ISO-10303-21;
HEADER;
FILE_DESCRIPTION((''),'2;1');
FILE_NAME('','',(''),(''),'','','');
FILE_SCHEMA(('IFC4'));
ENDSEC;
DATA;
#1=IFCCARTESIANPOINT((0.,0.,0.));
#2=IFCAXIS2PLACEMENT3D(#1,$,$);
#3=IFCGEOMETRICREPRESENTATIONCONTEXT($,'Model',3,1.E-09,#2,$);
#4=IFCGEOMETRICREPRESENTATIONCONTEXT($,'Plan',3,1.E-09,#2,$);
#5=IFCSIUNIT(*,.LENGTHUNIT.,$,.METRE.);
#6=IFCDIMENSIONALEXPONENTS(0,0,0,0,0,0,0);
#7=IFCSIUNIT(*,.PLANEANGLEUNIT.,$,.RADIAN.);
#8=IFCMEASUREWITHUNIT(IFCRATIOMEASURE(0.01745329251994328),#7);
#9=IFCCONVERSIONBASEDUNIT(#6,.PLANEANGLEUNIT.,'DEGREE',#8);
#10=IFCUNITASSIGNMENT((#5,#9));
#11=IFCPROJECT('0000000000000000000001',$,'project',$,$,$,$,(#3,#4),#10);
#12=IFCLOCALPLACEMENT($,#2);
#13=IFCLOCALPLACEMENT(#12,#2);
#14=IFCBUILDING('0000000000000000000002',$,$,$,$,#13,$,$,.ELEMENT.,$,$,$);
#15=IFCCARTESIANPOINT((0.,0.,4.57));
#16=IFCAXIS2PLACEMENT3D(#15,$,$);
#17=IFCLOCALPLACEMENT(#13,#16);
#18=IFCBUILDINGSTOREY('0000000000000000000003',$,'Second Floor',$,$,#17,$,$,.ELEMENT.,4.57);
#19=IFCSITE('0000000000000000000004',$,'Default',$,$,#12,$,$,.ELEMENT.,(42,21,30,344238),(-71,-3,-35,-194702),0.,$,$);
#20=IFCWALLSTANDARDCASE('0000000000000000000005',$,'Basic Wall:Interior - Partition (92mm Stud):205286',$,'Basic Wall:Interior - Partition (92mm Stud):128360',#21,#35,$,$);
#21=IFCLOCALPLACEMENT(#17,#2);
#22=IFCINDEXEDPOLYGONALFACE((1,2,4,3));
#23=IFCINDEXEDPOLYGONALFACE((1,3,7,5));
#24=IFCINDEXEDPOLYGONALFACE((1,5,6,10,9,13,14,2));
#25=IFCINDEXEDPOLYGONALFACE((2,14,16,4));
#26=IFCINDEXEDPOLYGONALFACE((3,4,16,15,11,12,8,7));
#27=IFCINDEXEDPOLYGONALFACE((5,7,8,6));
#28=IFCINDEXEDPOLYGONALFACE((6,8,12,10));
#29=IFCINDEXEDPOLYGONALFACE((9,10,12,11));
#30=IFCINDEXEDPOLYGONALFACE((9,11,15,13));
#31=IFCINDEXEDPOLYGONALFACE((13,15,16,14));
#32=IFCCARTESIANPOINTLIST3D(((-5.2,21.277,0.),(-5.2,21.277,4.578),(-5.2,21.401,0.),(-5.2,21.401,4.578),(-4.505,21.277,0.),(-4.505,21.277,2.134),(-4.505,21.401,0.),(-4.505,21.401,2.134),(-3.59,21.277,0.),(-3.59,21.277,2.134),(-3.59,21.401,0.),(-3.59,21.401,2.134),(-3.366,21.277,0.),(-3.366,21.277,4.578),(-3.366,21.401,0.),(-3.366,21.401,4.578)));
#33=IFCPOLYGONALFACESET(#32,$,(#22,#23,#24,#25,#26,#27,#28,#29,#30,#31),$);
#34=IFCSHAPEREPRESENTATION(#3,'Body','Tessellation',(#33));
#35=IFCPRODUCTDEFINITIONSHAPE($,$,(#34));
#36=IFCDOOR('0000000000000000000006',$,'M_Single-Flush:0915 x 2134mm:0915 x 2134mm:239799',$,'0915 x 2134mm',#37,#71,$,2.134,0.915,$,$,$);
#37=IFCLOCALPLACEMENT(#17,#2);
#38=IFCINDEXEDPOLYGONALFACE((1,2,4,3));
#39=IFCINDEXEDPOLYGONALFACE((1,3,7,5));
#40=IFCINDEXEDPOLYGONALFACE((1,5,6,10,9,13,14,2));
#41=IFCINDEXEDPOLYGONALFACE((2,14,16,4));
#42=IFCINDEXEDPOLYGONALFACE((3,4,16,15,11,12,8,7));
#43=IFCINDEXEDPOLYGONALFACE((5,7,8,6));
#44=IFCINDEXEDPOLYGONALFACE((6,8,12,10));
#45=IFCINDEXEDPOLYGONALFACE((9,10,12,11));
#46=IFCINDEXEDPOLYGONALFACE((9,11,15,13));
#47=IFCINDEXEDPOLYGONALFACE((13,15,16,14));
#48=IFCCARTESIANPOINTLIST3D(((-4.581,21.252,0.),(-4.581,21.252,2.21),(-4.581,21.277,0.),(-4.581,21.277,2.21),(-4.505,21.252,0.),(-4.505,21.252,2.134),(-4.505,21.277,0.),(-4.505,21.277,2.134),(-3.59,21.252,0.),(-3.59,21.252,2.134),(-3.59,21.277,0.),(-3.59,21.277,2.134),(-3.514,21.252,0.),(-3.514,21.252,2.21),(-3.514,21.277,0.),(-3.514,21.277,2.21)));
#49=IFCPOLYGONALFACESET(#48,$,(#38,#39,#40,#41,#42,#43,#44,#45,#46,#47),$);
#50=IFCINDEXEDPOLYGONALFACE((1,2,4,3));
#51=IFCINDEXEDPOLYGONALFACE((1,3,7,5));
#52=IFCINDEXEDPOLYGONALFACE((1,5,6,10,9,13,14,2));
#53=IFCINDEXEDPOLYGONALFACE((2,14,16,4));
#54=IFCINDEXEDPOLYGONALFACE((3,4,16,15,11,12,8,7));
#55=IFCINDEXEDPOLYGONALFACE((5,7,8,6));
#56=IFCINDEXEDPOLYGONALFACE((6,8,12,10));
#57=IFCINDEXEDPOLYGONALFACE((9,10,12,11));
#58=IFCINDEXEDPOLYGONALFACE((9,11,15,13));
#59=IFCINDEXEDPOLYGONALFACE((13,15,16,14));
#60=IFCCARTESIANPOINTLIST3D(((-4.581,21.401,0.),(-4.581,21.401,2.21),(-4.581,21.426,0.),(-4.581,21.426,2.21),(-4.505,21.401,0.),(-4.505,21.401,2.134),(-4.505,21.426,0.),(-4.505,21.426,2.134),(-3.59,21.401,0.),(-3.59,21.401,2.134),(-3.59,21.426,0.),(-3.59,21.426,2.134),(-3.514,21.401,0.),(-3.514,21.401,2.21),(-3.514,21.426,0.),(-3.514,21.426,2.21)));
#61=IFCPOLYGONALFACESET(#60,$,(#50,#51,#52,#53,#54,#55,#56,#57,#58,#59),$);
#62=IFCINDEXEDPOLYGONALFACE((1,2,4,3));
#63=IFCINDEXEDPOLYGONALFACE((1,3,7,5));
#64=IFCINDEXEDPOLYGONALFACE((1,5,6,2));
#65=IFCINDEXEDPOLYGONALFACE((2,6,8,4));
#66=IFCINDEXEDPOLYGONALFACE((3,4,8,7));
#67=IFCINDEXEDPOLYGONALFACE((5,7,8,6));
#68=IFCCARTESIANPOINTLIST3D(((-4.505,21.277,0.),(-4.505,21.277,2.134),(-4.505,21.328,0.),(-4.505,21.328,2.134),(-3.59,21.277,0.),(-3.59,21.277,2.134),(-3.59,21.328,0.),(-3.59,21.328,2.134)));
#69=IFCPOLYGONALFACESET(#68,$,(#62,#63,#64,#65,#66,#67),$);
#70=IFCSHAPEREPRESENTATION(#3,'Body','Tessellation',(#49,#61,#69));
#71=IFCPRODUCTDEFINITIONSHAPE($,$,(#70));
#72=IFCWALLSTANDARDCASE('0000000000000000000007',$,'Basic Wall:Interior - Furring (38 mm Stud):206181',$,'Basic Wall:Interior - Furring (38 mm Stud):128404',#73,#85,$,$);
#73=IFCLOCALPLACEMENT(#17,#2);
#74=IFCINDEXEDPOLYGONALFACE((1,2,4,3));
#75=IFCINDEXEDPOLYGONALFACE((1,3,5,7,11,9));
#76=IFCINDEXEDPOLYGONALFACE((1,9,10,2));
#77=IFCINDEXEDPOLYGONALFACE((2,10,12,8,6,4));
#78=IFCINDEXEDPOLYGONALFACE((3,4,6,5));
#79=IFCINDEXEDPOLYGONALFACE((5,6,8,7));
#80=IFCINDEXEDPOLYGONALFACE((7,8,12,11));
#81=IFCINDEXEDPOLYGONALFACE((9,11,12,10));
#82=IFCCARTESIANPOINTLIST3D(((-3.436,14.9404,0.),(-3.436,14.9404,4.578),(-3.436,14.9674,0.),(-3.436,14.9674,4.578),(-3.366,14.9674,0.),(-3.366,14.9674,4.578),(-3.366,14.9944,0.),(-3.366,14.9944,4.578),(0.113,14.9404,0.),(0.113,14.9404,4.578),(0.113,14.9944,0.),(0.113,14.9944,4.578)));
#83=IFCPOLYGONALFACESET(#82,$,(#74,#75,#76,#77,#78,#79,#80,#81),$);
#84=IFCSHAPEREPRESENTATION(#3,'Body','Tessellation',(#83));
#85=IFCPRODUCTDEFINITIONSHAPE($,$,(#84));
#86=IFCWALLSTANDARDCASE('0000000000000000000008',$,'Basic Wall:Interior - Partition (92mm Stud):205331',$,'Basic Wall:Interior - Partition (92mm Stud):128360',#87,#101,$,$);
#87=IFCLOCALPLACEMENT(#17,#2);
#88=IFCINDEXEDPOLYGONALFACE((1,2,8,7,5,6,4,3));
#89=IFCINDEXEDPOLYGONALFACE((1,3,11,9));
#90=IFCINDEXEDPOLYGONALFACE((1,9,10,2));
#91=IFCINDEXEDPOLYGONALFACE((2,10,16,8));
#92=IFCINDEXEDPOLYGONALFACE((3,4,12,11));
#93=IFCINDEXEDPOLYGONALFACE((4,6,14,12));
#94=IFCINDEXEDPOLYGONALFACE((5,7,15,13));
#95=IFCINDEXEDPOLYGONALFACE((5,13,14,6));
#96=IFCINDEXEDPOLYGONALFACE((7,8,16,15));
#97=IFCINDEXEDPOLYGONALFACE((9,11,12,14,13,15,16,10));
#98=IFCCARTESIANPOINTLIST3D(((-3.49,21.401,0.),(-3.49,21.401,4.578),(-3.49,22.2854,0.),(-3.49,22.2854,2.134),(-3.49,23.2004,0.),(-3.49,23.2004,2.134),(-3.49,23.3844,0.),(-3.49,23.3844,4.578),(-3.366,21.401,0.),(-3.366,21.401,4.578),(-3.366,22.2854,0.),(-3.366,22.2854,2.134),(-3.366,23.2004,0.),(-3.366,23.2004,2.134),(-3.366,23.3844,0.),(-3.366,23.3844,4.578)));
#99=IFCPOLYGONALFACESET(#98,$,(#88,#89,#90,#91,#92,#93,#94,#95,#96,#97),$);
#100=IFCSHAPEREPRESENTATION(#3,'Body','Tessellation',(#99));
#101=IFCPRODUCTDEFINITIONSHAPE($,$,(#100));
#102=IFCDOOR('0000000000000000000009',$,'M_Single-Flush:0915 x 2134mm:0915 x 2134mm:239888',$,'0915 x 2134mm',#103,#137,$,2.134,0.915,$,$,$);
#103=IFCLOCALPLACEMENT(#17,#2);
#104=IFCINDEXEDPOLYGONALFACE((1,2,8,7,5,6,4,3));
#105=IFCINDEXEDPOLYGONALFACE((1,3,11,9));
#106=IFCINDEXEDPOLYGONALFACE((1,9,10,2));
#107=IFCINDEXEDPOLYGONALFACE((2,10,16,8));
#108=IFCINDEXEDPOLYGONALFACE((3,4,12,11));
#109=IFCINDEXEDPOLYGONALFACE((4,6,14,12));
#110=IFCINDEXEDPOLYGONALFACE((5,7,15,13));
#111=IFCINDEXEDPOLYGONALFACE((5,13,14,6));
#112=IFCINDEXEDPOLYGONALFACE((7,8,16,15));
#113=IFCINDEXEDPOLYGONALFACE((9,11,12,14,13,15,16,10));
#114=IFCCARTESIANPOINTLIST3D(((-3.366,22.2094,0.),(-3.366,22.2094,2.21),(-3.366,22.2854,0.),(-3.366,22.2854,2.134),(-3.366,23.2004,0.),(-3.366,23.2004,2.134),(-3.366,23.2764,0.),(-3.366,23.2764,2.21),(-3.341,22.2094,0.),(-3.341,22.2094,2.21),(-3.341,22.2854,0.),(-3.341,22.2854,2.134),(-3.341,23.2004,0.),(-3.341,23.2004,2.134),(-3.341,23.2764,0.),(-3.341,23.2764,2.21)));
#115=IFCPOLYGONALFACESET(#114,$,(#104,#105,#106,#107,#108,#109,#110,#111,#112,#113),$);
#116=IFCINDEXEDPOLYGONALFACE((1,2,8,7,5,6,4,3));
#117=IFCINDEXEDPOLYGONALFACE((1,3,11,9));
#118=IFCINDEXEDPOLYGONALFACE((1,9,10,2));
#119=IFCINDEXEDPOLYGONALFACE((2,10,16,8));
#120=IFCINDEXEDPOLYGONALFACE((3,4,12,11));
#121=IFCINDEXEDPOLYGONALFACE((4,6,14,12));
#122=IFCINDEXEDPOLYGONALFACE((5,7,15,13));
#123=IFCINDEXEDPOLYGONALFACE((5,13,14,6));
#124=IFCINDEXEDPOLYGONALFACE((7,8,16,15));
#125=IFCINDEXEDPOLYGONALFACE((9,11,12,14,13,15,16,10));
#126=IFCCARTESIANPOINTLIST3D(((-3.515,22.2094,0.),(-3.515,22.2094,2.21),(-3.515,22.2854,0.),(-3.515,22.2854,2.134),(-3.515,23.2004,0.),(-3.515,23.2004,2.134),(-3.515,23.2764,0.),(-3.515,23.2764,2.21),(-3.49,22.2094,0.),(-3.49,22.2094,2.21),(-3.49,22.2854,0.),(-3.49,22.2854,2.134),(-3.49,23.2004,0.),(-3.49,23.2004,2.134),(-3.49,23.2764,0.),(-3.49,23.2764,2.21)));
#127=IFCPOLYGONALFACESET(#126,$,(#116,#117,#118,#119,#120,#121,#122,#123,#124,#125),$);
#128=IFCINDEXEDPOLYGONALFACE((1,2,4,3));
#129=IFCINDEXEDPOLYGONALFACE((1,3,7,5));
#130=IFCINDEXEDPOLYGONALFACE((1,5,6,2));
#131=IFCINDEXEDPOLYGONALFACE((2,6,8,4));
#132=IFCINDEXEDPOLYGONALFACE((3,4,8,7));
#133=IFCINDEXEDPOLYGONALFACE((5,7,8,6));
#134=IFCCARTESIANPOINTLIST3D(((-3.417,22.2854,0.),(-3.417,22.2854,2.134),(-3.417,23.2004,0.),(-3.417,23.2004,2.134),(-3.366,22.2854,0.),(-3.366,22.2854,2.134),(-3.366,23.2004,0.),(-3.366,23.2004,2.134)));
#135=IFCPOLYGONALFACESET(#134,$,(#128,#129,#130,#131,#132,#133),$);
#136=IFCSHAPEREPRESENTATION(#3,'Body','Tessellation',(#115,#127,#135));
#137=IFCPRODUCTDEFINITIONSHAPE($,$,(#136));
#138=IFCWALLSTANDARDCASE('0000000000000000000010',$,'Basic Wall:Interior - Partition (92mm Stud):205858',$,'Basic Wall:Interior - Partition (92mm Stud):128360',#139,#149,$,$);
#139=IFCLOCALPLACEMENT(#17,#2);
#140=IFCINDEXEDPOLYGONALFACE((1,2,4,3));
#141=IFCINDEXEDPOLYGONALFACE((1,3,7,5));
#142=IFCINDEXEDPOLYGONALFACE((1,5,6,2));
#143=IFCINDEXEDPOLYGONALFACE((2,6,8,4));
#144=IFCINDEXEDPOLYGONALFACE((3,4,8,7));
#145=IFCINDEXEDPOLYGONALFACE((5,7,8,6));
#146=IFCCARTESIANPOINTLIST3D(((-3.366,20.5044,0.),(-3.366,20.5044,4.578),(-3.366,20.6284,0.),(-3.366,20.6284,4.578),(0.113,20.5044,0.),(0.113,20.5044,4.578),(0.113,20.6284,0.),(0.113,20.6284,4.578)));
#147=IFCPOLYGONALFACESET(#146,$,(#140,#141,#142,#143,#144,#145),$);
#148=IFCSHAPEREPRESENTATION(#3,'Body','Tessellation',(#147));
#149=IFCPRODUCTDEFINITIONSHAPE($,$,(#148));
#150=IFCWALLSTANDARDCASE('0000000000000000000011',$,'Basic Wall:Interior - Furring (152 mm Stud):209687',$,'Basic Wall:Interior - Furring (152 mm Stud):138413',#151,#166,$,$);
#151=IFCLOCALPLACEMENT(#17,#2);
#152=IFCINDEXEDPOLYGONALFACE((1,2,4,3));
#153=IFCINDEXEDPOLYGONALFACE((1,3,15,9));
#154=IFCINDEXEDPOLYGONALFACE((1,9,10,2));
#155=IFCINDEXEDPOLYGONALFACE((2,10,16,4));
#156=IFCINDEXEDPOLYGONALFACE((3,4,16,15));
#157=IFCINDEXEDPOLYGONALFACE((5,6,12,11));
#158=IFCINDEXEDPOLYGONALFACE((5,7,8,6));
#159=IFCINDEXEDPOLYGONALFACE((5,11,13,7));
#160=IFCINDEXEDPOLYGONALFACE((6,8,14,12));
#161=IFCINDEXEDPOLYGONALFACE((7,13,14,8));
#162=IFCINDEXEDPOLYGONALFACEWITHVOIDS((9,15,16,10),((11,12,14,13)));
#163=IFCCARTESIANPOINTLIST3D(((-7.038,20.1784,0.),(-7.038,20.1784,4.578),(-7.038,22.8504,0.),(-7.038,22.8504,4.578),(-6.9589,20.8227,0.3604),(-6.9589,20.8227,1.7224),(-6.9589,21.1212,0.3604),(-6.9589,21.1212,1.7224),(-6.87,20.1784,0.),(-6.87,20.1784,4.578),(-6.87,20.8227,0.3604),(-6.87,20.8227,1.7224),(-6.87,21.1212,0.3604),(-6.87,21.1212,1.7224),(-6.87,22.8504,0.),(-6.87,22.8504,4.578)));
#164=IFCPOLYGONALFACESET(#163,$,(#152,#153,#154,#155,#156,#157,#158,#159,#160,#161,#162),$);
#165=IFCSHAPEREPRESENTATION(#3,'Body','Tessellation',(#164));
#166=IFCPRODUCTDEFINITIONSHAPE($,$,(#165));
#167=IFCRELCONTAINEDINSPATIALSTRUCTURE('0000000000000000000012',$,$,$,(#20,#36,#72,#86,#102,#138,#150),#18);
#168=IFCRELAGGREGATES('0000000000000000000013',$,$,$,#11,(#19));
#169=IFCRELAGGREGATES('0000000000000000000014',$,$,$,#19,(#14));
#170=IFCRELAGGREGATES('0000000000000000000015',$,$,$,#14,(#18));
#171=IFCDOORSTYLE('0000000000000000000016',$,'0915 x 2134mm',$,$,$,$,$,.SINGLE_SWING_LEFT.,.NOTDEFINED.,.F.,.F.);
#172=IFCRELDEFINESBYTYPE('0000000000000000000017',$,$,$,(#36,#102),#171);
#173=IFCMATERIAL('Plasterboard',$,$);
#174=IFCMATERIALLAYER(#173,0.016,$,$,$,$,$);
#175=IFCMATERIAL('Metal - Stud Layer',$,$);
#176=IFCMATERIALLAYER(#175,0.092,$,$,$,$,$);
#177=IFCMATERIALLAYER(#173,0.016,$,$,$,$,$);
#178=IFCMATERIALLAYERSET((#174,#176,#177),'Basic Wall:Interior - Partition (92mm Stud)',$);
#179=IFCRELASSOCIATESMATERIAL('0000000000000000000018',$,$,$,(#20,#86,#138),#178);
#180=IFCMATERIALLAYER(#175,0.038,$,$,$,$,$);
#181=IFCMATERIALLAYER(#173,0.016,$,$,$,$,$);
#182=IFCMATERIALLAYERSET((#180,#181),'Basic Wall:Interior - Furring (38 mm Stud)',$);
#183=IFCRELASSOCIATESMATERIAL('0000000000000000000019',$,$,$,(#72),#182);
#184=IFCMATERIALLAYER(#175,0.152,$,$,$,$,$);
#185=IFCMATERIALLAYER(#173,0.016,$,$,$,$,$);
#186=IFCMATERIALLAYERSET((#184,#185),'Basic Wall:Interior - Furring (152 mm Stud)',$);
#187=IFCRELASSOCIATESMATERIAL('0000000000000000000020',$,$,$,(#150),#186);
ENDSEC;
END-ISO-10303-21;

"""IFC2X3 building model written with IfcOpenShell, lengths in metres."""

from ifc_helpers import new_model, entity, si_unit, converted_unit, frame, frame_2d, origin, origin_2d_with_axis, place, context, project, spatial, polyline, rectangle, outline, extrude, source, transform, mapped, material, layer, layer_set, layer_usage, type_object, type_shapes, element, fill, save


model = new_model("IFC2X3")

# Units and contexts
model_context = context("Model", 3, precision=1e-09, world=origin())
plan_context = context("Plan", 3, precision=1e-09, world=origin())
ifc_project = project(units=[si_unit("LENGTHUNIT", "METRE"), converted_unit("PLANEANGLEUNIT", "DEGREE", entity("IfcRatioMeasure", 0.01745329251994328), si_unit("PLANEANGLEUNIT", "RADIAN"), dimensions=[0, 0, 0, 0, 0, 0, 0])], contexts=[model_context, plan_context])

# Site, building, storey
site_placement = place(None, origin())
site = spatial("IfcSite", under=ifc_project, at=site_placement, Name="Default", CompositionType="ELEMENT", RefLatitude=(42, 21, 30, 344238), RefLongitude=(-71, -3, -35, -194702), RefElevation=0.0)
building_placement = place(site_placement, origin())
building = spatial("IfcBuilding", under=site, at=building_placement, CompositionType="ELEMENT")
storey_placement = place(building_placement, frame((0.0, 0.0, 4.57)))
storey = spatial("IfcBuildingStorey", under=building, at=storey_placement, Name="Second Floor", CompositionType="ELEMENT", Elevation=4.57)

# Shared definitions
ifc_material_1 = material(Name="Plasterboard")
ifc_layer_1 = layer(ifc_material_1, 0.016)
ifc_material_2 = material(Name="Metal - Stud Layer")
ifc_layer_2 = layer(ifc_material_2, 0.092)
ifc_layer_3 = layer(ifc_material_1, 0.016)
ifc_layer_set_1 = layer_set([ifc_layer_1, ifc_layer_2, ifc_layer_3], Name="Basic Wall:Interior - Partition (92mm Stud)")
ifc_layer_usage_1 = layer_usage(ifc_layer_set_1, "AXIS2", "NEGATIVE", 0.062)

# Shared definitions
ifc_layer_4 = layer(ifc_material_2, 0.038)
ifc_layer_5 = layer(ifc_material_1, 0.016)
ifc_layer_set_2 = layer_set([ifc_layer_4, ifc_layer_5], Name="Basic Wall:Interior - Furring (38 mm Stud)")
ifc_layer_usage_2 = layer_usage(ifc_layer_set_2, "AXIS2", "NEGATIVE", 0.027)

# Wall, opening, door
wall_1_placement = place(storey_placement, frame((-5.2, 21.339, 0.0)))
wall_1 = element("IfcWallStandardCase", 1, at=wall_1_placement, inside=storey, material=ifc_layer_usage_1, Name="Basic Wall:Interior - Partition (92mm Stud):205286", ObjectType="Basic Wall:Interior - Partition (92mm Stud):128360", context=model_context, shape_type="SweptSolid", body=[
    extrude(rectangle(XDim=1.834, YDim=0.124, at=frame_2d((0.917, 0.0), x_axis=(-1.0, 0.0))), origin(), (0.0, 0.0, 1.0), 4.578),
])
opening_1_placement = place(wall_1_placement, frame((1.61, 0.062, 0.0)))
opening_1 = element("IfcOpeningElement", 2, at=opening_1_placement, cuts=wall_1, ObjectType="Opening", context=model_context, shape_type="SweptSolid", body=[
    extrude(rectangle(XDim=0.915, YDim=2.134, at=frame_2d((1.067, 0.4575), x_axis=(0.0, -1.0))), frame((0.0, 0.0, 0.0), z_axis=(0.0, -1.0, 0.0), x_axis=(0.0, 0.0, 1.0)), (0.0, 0.0, 1.0), 0.124),
])
door_style_1 = type_object("IfcDoorStyle", Name="0915 x 2134mm", ConstructionType="NOTDEFINED", OperationType="SINGLE_SWING_LEFT", ParameterTakesPrecedence=False, Sizeable=False)
shared_shape_1 = source(origin(), model_context, "Body", "SweptSolid", [
    extrude(outline(polyline([(-0.5335, -1.124), (0.5335, -1.124), (0.5335, 1.086), (0.4575, 1.086), (0.4575, -1.048), (-0.4575, -1.048), (-0.4575, 1.086), (-0.5335, 1.086), (-0.5335, -1.124)])), frame((0.4575, 0.149, 1.086), z_axis=(0.0, -1.0, 0.0), x_axis=(-1.0, 0.0, 0.0)), (0.0, 0.0, 1.0), 0.025),
    extrude(outline(polyline([(-1.124, -0.5335), (1.086, -0.5335), (1.086, -0.4575), (-1.048, -0.4575), (-1.048, 0.4575), (1.086, 0.4575), (1.086, 0.5335), (-1.124, 0.5335), (-1.124, -0.5335)])), frame((0.4575, 0.0, 1.086), z_axis=(0.0, -1.0, 0.0), x_axis=(0.0, 0.0, -1.0)), (0.0, 0.0, 1.0), 0.025),
    extrude(rectangle(XDim=0.915, YDim=0.051, at=origin_2d_with_axis()), frame((0.4575, 0.0985, 0.0)), (0.0, 0.0, 1.0), 2.134),
])
type_shapes(door_style_1, [shared_shape_1])
door_1_placement = place(opening_1_placement, frame((0.0, 0.0, 0.0), z_axis=(0.0, 0.0, 1.0), x_axis=(-1.0, 0.0, 0.0)))
door_1 = element("IfcDoor", 3, at=door_1_placement, inside=storey, type_object=door_style_1, Name="M_Single-Flush:0915 x 2134mm:0915 x 2134mm:239799", ObjectType="0915 x 2134mm", OverallHeight=2.134, OverallWidth=0.915, context=model_context, shape_type="MappedRepresentation", body=[
    mapped(shared_shape_1, transform((0.0, 0.0, 0.0), scale=1.0)),
])
fill(opening_1, door_1)

# Wall
wall_2_placement = place(storey_placement, frame((0.113, 14.9674, 0.0), z_axis=(0.0, 0.0, 1.0), x_axis=(-1.0, 0.0, 0.0)))
element("IfcWallStandardCase", 4, at=wall_2_placement, inside=storey, material=ifc_layer_usage_2, Name="Basic Wall:Interior - Furring (38 mm Stud):206181", ObjectType="Basic Wall:Interior - Furring (38 mm Stud):128404", context=model_context, shape_type="SweptSolid", body=[
    extrude(outline(polyline([(3.479, -0.027), (3.479, 0.0), (3.549, 0.0), (3.549, 0.027), (0.0, 0.027), (0.0, -0.027), (3.479, -0.027)])), origin(), (0.0, 0.0, 1.0), 4.578),
])

# Wall, opening, door
wall_3_placement = place(storey_placement, frame((-3.428, 21.401, 0.0), z_axis=(0.0, 0.0, 1.0), x_axis=(0.0, 1.0, 0.0)))
wall_3 = element("IfcWallStandardCase", 5, at=wall_3_placement, inside=storey, material=ifc_layer_usage_1, Name="Basic Wall:Interior - Partition (92mm Stud):205331", ObjectType="Basic Wall:Interior - Partition (92mm Stud):128360", context=model_context, shape_type="SweptSolid", body=[
    extrude(rectangle(XDim=1.9834, YDim=0.124, at=frame_2d((0.9917, 0.0), x_axis=(-1.0, 0.0))), origin(), (0.0, 0.0, 1.0), 4.578),
])
opening_2_placement = place(wall_3_placement, frame((1.7994, 0.062, 0.0)))
opening_2 = element("IfcOpeningElement", 6, at=opening_2_placement, cuts=wall_3, ObjectType="Opening", context=model_context, shape_type="SweptSolid", body=[
    extrude(rectangle(XDim=0.915, YDim=2.134, at=frame_2d((1.067, 0.4575), x_axis=(0.0, -1.0))), frame((0.0, 0.0, 0.0), z_axis=(0.0, -1.0, 0.0), x_axis=(0.0, 0.0, 1.0)), (0.0, 0.0, 1.0), 0.124),
])
door_2_placement = place(opening_2_placement, frame((0.0, 0.0, 0.0), z_axis=(0.0, 0.0, 1.0), x_axis=(-1.0, 0.0, 0.0)))
door_2 = element("IfcDoor", 7, at=door_2_placement, inside=storey, type_object=door_style_1, Name="M_Single-Flush:0915 x 2134mm:0915 x 2134mm:239888", ObjectType="0915 x 2134mm", OverallHeight=2.134, OverallWidth=0.915, context=model_context, shape_type="MappedRepresentation", body=[
    mapped(shared_shape_1, transform((0.0, 0.0, 0.0), scale=1.0)),
])
fill(opening_2, door_2)

# Wall
wall_4_placement = place(storey_placement, frame((0.113, 20.5664, 0.0), z_axis=(0.0, 0.0, 1.0), x_axis=(-1.0, 0.0, 0.0)))
element("IfcWallStandardCase", 8, at=wall_4_placement, inside=storey, material=ifc_layer_usage_1, Name="Basic Wall:Interior - Partition (92mm Stud):205858", ObjectType="Basic Wall:Interior - Partition (92mm Stud):128360", context=model_context, shape_type="SweptSolid", body=[
    extrude(rectangle(XDim=3.479, YDim=0.124, at=frame_2d((1.7395, 0.0), x_axis=(-1.0, 0.0))), origin(), (0.0, 0.0, 1.0), 4.578),
])

# Wall, opening
ifc_layer_6 = layer(ifc_material_2, 0.152)
ifc_layer_7 = layer(ifc_material_1, 0.016)
ifc_layer_set_3 = layer_set([ifc_layer_6, ifc_layer_7], Name="Basic Wall:Interior - Furring (152 mm Stud)")
ifc_layer_usage_3 = layer_usage(ifc_layer_set_3, "AXIS2", "POSITIVE", -0.084)
wall_5_placement = place(storey_placement, frame((-6.954, 22.8504, 0.0), z_axis=(0.0, 0.0, 1.0), x_axis=(0.0, -1.0, 0.0)))
wall_5 = element("IfcWallStandardCase", 9, at=wall_5_placement, inside=storey, material=ifc_layer_usage_3, Name="Basic Wall:Interior - Furring (152 mm Stud):209687", ObjectType="Basic Wall:Interior - Furring (152 mm Stud):138413", context=model_context, shape_type="SweptSolid", body=[
    extrude(rectangle(XDim=2.672, YDim=0.168, at=frame_2d((1.336, 0.0), x_axis=(-1.0, 0.0))), origin(), (0.0, 0.0, 1.0), 4.578),
])
opening_3_placement = place(wall_5_placement, origin())
element("IfcOpeningElement", 10, at=opening_3_placement, cuts=wall_5, ObjectType="Opening", context=model_context, shape_type="SweptSolid", body=[
    extrude(rectangle(XDim=1.3621, YDim=0.2985, at=frame_2d((0.0, 0.0), x_axis=(0.0, 1.0))), frame((1.8785, -0.0049, 1.0414), z_axis=(0.0, 1.0, 0.0), x_axis=(1.0, 0.0, 0.0)), (0.0, 0.0, 1.0), 0.1524),
])

save(model, "model.ifc")
